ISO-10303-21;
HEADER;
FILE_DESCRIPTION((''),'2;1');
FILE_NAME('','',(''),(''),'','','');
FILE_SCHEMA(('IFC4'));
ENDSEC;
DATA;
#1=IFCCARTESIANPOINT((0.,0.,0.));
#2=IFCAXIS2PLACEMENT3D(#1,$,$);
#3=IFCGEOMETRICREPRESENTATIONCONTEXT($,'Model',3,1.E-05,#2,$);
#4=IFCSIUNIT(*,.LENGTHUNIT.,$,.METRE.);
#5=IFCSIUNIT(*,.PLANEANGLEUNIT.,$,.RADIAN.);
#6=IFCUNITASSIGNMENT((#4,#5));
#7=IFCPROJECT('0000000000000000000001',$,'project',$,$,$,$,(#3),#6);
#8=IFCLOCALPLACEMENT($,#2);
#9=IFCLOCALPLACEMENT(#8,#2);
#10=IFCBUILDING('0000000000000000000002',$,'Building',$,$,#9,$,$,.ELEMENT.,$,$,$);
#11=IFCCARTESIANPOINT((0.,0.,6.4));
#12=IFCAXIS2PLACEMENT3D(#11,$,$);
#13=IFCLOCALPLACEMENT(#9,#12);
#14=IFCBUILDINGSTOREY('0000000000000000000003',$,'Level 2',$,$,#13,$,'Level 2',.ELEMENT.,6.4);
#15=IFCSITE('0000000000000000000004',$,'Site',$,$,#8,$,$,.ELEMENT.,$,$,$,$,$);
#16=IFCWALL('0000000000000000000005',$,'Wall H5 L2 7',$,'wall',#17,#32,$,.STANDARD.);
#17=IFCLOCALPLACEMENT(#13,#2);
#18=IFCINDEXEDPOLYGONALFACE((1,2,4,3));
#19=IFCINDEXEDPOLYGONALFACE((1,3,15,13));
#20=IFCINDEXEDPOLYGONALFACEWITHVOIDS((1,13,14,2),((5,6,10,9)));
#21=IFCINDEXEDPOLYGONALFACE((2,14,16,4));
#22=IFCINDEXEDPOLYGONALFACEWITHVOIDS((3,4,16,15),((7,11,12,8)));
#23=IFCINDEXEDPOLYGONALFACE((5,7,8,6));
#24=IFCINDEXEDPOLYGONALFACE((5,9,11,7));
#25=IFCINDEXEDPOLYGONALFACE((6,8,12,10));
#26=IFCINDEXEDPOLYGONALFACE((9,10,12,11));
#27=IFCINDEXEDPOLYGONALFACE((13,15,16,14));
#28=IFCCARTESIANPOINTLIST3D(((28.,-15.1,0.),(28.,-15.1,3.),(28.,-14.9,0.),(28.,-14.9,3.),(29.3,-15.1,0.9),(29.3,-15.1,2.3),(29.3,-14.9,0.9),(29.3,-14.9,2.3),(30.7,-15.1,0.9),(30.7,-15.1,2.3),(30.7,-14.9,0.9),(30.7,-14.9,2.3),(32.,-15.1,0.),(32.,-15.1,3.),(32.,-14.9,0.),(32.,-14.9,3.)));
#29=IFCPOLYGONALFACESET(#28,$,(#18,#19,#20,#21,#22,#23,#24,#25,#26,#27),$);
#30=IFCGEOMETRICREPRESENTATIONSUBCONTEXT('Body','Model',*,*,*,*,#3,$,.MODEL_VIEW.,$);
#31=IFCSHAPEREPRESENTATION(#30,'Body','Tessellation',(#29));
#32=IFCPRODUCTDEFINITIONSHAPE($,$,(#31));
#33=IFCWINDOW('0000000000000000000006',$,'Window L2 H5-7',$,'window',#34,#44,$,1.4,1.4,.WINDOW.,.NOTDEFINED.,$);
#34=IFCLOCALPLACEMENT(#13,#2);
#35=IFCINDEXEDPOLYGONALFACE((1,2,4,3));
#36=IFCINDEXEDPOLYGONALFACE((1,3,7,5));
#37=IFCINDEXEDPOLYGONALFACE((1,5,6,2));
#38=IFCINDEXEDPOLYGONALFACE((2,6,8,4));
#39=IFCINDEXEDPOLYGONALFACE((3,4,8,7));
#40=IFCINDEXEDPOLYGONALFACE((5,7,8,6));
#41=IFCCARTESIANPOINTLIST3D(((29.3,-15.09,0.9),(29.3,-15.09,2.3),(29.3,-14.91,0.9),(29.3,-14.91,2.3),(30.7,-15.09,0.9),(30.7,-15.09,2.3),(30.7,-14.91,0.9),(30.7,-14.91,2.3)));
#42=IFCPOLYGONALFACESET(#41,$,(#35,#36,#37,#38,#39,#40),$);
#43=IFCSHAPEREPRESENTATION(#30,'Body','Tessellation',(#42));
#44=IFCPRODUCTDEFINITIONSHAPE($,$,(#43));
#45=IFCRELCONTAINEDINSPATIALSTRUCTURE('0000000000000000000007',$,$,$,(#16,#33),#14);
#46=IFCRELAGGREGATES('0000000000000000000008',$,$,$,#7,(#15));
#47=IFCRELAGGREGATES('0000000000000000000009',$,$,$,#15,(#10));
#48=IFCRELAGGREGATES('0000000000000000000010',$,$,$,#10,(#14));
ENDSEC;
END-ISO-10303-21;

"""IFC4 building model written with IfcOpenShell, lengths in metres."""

from ifc_helpers import new_model, si_unit, frame, frame_2d, origin, origin_2d, place, context, subcontext, project, spatial, rectangle, extrude, element, fill, save


model = new_model("IFC4")

# Units and contexts
model_context = context("Model", 3, precision=1e-05, world=origin())
body_context = subcontext(model_context, "Body", "Model", "MODEL_VIEW")
ifc_project = project(units=[si_unit("LENGTHUNIT", "METRE"), si_unit("PLANEANGLEUNIT", "RADIAN")], contexts=[model_context])

# Site, building, storey
site_placement = place(None, origin())
site = spatial("IfcSite", under=ifc_project, at=site_placement, Name="Site", CompositionType="ELEMENT")
building_placement = place(site_placement, origin())
building = spatial("IfcBuilding", under=site, at=building_placement, Name="Building", CompositionType="ELEMENT")
storey_placement = place(building_placement, frame((0.0, 0.0, 6.4)))
storey = spatial("IfcBuildingStorey", under=building, at=storey_placement, Name="Level 2", LongName="Level 2", CompositionType="ELEMENT", Elevation=6.4)

# Wall, opening, window
wall_1_placement = place(storey_placement, frame((28.0, -15.0, 0.0), z_axis=(0.0, 0.0, 1.0), x_axis=(1.0, 0.0, 0.0)))
wall_1 = element("IfcWall", 1, at=wall_1_placement, inside=storey, Name="Wall H5 L2 7", ObjectType="wall", PredefinedType="STANDARD", context=body_context, shape_type="SweptSolid", body=[
    extrude(rectangle(XDim=4.0, YDim=0.2, at=frame_2d((2.0, 0.0))), origin(), (0.0, 0.0, 1.0), 3.0),
])
opening_1_placement = place(storey_placement, frame((30.0, -15.0, 0.9), z_axis=(0.0, 0.0, 1.0), x_axis=(1.0, 0.0, 0.0)))
opening_1 = element("IfcOpeningElement", 2, at=opening_1_placement, cuts=wall_1, ObjectType="Opening", PredefinedType="OPENING", context=body_context, shape_type="SweptSolid", body=[
    extrude(rectangle(XDim=1.4, YDim=0.22, at=origin_2d()), origin(), (0.0, 0.0, 1.0), 1.4),
])
window_1_placement = place(storey_placement, frame((30.0, -15.0, 0.9), z_axis=(0.0, 0.0, 1.0), x_axis=(1.0, 0.0, 0.0)))
window_1 = element("IfcWindow", 3, at=window_1_placement, inside=storey, Name="Window L2 H5-7", ObjectType="window", OverallHeight=1.4, OverallWidth=1.4, PartitioningType="NOTDEFINED", PredefinedType="WINDOW", context=body_context, shape_type="SweptSolid", body=[
    extrude(rectangle(XDim=1.4, YDim=0.18, at=origin_2d()), origin(), (0.0, 0.0, 1.0), 1.4),
])
fill(opening_1, window_1)

save(model, "model.ifc")
